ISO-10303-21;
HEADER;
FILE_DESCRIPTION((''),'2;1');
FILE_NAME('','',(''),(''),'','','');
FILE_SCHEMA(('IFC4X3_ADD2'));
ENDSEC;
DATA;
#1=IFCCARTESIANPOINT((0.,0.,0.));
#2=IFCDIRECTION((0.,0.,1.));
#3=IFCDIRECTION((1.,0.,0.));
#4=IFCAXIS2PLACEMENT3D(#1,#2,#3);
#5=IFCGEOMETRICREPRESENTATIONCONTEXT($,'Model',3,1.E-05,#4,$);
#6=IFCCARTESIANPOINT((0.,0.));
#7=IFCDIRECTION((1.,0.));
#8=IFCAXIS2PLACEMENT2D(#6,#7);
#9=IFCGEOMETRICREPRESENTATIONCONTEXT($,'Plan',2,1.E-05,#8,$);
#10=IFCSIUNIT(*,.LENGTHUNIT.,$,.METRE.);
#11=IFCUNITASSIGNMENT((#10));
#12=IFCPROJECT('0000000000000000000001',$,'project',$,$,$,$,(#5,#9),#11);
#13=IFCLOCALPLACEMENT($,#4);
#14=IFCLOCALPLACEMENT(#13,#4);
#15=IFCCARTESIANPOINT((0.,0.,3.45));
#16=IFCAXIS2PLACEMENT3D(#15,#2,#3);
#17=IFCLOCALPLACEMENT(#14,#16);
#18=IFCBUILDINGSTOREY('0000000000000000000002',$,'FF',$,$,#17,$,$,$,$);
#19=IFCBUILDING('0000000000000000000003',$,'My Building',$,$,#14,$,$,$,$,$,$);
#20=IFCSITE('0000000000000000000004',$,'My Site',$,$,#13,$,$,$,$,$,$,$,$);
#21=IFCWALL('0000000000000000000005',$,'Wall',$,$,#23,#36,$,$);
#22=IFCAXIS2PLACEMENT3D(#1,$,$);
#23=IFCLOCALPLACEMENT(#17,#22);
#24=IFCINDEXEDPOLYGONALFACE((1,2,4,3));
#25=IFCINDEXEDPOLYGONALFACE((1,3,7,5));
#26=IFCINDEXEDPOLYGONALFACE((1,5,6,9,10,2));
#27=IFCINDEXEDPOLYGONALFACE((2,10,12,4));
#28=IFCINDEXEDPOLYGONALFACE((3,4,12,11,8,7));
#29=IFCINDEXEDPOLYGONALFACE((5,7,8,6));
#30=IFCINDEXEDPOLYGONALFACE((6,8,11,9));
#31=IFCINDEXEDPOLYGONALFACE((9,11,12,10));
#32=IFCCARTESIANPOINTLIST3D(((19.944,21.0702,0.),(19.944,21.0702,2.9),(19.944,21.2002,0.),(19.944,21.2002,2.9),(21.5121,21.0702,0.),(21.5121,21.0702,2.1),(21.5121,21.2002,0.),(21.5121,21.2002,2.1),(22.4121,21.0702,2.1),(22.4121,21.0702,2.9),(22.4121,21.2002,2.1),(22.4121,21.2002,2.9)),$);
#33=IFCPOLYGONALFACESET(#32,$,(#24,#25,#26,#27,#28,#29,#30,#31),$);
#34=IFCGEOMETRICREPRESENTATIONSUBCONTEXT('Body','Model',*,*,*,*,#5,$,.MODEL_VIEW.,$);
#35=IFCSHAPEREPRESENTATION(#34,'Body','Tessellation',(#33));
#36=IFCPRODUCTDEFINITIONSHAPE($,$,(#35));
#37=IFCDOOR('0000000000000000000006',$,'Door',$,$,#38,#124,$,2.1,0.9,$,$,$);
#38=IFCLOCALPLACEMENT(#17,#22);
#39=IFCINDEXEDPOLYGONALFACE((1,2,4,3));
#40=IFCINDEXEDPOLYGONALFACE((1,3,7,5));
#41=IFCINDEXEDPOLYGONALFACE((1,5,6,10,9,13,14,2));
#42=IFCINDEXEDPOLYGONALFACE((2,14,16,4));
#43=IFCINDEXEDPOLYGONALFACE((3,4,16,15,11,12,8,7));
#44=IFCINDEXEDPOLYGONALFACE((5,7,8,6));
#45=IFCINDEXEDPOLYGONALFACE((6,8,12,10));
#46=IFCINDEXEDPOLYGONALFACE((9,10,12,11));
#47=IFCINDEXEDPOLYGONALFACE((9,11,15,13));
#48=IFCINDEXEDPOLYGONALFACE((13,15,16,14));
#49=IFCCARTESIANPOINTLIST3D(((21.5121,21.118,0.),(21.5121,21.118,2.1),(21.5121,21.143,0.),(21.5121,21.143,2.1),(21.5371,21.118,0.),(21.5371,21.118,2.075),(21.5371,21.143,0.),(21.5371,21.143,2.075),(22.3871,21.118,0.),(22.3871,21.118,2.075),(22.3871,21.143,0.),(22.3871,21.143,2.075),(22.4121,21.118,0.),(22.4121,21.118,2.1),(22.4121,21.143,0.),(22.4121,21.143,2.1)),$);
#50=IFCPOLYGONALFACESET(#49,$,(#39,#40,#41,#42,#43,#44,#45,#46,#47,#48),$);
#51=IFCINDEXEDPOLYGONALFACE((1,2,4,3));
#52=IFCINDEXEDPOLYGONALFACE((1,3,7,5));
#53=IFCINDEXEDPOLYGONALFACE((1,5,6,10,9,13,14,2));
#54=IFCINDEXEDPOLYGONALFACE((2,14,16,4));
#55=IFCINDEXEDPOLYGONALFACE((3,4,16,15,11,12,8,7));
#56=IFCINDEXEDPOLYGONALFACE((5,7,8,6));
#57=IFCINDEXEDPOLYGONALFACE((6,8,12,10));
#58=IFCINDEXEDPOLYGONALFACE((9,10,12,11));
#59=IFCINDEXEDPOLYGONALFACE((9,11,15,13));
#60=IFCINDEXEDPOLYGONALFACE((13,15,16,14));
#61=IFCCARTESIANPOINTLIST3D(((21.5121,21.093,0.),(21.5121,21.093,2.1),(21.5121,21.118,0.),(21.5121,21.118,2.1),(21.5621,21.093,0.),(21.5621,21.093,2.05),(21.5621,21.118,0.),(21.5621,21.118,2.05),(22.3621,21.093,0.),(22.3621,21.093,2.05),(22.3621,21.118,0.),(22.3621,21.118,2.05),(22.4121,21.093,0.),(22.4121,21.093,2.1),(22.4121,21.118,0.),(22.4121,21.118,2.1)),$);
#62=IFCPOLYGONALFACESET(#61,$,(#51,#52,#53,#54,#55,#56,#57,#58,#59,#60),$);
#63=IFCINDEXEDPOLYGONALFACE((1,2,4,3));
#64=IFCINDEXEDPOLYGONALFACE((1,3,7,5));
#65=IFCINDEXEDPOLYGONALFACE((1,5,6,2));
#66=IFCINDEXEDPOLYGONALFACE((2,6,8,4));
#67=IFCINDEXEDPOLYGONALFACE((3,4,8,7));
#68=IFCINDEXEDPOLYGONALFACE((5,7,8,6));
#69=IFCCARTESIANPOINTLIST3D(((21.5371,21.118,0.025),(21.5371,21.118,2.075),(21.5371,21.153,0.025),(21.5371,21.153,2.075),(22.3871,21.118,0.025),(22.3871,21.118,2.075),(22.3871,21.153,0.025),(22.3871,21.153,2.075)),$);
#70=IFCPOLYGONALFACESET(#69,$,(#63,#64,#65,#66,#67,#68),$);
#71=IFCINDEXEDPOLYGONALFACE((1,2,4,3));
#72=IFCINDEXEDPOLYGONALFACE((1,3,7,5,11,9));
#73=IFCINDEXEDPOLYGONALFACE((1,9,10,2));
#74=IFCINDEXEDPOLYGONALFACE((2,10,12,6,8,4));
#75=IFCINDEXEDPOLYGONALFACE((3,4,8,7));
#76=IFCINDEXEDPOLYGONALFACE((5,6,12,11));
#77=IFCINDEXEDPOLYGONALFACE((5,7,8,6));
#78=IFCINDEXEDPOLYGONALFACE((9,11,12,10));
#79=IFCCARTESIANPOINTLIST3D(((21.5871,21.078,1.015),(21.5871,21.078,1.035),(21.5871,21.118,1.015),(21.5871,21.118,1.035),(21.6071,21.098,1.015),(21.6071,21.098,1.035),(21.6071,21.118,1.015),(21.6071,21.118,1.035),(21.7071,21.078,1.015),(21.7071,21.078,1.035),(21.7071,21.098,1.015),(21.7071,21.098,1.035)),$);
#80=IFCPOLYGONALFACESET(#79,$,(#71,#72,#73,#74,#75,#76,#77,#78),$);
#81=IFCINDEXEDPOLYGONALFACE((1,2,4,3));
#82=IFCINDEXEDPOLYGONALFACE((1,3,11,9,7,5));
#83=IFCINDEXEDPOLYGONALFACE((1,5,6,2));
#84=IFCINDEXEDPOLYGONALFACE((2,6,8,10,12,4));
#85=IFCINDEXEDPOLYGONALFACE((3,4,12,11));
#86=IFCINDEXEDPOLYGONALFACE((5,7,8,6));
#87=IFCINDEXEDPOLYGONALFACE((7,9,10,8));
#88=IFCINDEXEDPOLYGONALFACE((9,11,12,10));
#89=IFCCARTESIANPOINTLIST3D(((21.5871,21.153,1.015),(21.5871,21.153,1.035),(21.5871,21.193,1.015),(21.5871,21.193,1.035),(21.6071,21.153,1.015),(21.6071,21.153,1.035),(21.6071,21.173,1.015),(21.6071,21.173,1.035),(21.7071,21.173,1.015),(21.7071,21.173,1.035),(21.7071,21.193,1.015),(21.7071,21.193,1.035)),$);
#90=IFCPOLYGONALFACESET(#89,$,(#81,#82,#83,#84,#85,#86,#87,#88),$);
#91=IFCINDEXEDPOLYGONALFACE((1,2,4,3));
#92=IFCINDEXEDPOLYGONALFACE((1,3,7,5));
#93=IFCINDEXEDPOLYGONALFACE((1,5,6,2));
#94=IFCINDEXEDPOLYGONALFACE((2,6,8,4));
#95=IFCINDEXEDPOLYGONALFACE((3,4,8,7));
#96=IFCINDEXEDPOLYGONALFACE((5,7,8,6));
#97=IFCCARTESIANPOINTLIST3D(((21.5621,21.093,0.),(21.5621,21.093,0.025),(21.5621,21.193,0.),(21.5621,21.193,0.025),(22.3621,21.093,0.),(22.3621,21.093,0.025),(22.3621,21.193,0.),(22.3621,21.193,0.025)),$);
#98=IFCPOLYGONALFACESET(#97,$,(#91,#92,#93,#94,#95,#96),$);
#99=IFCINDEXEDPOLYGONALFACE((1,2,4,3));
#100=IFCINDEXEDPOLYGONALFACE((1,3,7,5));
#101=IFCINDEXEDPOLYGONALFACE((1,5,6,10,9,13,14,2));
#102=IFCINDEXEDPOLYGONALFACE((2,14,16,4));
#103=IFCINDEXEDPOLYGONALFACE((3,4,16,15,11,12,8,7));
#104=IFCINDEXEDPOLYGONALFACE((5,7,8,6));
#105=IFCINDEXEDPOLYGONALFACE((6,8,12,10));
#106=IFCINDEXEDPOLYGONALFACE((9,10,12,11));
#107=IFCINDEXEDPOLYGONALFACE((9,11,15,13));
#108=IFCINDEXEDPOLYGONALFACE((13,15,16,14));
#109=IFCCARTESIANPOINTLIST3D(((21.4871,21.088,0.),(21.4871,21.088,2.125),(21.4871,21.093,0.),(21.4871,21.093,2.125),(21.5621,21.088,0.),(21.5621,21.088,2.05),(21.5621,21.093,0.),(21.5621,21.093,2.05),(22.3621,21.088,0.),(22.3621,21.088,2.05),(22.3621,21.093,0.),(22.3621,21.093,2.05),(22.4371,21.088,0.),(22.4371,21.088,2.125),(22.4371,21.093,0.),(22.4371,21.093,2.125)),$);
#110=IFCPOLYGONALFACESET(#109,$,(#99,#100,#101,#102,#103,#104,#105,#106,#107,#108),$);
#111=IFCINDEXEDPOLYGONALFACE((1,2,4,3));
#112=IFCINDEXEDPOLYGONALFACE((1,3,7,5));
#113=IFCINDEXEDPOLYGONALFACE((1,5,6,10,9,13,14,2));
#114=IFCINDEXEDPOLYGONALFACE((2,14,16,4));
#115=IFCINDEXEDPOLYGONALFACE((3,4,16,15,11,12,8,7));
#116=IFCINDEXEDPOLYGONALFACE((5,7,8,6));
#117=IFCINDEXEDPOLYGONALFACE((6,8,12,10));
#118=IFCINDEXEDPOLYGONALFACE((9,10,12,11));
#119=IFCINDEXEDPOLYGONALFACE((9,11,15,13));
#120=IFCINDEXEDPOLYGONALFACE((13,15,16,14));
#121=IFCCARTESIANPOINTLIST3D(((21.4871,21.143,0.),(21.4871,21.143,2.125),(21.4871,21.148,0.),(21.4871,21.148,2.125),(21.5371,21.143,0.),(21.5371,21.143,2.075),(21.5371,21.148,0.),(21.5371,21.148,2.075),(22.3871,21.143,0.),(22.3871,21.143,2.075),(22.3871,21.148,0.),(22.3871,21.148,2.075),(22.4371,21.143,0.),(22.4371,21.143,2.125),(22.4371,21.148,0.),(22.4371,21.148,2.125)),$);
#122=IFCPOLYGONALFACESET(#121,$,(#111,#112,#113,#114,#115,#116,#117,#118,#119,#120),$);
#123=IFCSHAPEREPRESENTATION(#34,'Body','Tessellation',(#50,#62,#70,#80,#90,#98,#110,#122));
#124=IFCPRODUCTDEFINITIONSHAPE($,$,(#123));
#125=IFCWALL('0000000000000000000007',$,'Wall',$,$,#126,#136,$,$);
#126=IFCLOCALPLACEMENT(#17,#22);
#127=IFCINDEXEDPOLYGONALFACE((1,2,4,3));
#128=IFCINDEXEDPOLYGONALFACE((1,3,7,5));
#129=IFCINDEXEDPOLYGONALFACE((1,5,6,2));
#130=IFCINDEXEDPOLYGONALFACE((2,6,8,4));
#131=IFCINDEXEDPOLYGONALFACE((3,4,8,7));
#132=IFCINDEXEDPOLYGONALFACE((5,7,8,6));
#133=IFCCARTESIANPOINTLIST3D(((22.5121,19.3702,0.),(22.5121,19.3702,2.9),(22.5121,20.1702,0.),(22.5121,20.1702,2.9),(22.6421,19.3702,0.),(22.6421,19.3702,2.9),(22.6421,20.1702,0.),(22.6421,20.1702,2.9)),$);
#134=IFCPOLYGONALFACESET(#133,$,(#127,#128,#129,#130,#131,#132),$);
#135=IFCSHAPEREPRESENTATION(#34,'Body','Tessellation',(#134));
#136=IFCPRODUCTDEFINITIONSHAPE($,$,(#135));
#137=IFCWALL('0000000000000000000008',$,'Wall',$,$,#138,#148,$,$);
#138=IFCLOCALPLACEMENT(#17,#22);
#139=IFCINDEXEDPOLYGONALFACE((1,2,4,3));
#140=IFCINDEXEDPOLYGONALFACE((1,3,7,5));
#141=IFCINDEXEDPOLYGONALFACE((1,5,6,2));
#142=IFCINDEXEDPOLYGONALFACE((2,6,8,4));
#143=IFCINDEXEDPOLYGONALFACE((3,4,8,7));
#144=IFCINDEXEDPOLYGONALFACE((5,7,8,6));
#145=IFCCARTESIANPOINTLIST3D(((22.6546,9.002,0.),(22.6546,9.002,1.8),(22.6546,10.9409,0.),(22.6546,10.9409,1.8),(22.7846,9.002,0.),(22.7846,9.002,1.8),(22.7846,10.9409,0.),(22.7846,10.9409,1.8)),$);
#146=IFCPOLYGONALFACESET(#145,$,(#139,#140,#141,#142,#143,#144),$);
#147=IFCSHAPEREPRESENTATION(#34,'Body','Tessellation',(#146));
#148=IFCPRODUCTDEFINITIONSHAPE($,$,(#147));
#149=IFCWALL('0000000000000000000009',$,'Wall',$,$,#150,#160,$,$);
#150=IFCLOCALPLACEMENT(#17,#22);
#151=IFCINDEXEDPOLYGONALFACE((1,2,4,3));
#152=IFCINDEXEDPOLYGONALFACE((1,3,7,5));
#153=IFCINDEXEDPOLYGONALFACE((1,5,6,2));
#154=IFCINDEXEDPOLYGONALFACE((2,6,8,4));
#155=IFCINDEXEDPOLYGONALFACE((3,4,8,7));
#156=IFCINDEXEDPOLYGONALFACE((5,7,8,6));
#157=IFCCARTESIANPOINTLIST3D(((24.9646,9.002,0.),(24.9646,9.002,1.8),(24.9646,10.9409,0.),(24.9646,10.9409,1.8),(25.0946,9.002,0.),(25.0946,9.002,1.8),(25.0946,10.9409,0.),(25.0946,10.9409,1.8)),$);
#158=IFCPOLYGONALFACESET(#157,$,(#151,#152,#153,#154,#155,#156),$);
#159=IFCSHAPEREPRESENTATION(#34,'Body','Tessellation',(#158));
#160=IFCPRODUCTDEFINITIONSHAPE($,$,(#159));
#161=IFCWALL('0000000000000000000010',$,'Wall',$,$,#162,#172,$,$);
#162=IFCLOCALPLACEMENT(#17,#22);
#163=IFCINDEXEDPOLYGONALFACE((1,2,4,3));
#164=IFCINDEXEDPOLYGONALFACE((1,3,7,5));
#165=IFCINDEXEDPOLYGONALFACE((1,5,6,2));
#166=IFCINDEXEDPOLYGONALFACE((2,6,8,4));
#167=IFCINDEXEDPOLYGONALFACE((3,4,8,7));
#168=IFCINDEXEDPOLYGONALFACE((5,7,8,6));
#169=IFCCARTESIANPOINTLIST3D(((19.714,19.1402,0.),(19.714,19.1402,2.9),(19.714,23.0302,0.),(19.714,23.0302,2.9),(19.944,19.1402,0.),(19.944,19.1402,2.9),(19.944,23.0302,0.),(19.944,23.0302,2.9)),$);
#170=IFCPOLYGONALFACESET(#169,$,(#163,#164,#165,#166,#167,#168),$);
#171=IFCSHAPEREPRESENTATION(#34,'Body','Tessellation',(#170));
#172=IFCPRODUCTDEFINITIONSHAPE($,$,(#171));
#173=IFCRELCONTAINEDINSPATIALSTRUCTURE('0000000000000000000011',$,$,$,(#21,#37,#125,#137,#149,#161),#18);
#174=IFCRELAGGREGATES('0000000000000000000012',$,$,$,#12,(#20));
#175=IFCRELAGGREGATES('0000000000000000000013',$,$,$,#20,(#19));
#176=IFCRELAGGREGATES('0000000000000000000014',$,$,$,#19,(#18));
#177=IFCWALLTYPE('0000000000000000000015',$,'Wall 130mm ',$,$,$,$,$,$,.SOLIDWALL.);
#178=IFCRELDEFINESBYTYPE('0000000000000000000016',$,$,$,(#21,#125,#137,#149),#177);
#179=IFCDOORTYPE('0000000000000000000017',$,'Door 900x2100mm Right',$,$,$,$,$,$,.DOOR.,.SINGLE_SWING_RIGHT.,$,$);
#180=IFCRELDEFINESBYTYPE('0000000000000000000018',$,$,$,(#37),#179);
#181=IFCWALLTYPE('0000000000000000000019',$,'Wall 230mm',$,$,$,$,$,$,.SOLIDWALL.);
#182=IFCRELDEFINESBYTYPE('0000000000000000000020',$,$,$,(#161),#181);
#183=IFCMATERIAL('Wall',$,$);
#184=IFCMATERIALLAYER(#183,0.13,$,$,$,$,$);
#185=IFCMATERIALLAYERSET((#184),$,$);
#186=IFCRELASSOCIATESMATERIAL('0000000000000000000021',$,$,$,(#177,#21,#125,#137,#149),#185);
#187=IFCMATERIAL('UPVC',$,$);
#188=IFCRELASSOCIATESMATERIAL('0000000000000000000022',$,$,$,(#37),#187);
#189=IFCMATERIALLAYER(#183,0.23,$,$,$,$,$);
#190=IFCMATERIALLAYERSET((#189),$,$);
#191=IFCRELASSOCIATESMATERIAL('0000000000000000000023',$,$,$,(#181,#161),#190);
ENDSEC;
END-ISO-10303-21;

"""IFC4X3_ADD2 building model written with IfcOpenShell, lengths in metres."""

from ifc_helpers import new_model, entity, si_unit, frame, origin_with_axes, origin_2d_with_axis, place, context, subcontext, project, spatial, line, indexed_curve, outline, extrude, shape, source, transform, mapped, material, layer, layer_set, layer_usage, type_object, type_shapes, element, fill, save


model = new_model("IFC4X3_ADD2")

# Units and contexts
model_context = context("Model", 3, precision=1e-05, world=origin_with_axes())
plan_context = context("Plan", 2, precision=1e-05, world=origin_2d_with_axis())
body_context_1 = subcontext(model_context, "Body", "Model", "MODEL_VIEW")
body_context_2 = subcontext(plan_context, "Body", "Plan", "PLAN_VIEW")
ifc_project = project(units=[si_unit("LENGTHUNIT", "METRE")], contexts=[model_context, plan_context])

# Site, building, storey
site_placement = place(None, origin_with_axes())
site = spatial("IfcSite", under=ifc_project, at=site_placement, Name="My Site")
building_placement = place(site_placement, origin_with_axes())
building = spatial("IfcBuilding", under=site, at=building_placement, Name="My Building")
storey_placement = place(building_placement, frame((0.0, 0.0, 3.45), z_axis=(0.0, 0.0, 1.0), x_axis=(1.0, 0.0, 0.0)))
storey = spatial("IfcBuildingStorey", under=building, at=storey_placement, Name="FF")

# Wall, opening, door
ifc_material_1 = material(Name="Wall")
ifc_layer_1 = layer(ifc_material_1, 0.13)
ifc_layer_set_1 = layer_set([ifc_layer_1])
ifc_layer_usage_1 = layer_usage(ifc_layer_set_1, "AXIS2", "POSITIVE", 0.0)
wall_type_1 = type_object("IfcWallType", Name="Wall 130mm ", PredefinedType="SOLIDWALL", material=ifc_layer_set_1)
wall_1_placement = place(storey_placement, frame((22.4121, 21.2002, 0.0), z_axis=(0.0, 0.0, 1.0), x_axis=(-1.0, 0.0, 0.0)))
wall_1 = element("IfcWall", 1, at=wall_1_placement, inside=storey, type_object=wall_type_1, material=ifc_layer_usage_1, Name="Wall", context=body_context_1, shape_type="SweptSolid", body=[
    extrude(outline(indexed_curve([(0.0, 0.0), (0.0, 0.13), (2.4681, 0.13), (2.4681, 0.0), (0.0, 0.0)], self_intersect=False)), origin_with_axes(), (0.0, 0.0, 1.0), 2.9),
])
shared_shape_1 = source(origin_with_axes(), body_context_1, "Body", "SweptSolid", [
    extrude(outline(indexed_curve([(0.0, 0.0), (0.9, 0.0), (0.9, 2.1), (0.0, 2.1)], segments=[line(1, 2, 3, 4, 1)])), frame((0.0, -0.6, 0.0), z_axis=(0.0, -1.0, 0.0), x_axis=(1.0, 0.0, 0.0)), (0.0, 0.0, -1.0), 1.2),
])
opening_1_placement = place(wall_1_placement, frame((0.9, 0.1072, 0.0), z_axis=(0.0, 0.0, 1.0), x_axis=(-1.0, 0.0, 0.0)))
opening_1 = element("IfcOpeningElement", 2, at=opening_1_placement, cuts=wall_1, PredefinedType="OPENING", context=body_context_1, shape_type="MappedRepresentation", body=[
    mapped(shared_shape_1, transform((0.0, 0.0, 0.0), x_axis=(1.0, 0.0, 0.0), y_axis=(0.0, 1.0, 0.0), z_axis=(0.0, 0.0, 1.0), scale=1.0)),
])
ifc_material_2 = material(Name="UPVC")
door_type_1 = type_object("IfcDoorType", Name="Door 900x2100mm Right", OperationType="SINGLE_SWING_RIGHT", PredefinedType="DOOR")
shared_shape_2 = source(origin_with_axes(), body_context_1, "Body", "SweptSolid", [
    extrude(outline(indexed_curve([(0.0, 0.0), (0.0, 2.1), (0.9, 2.1), (0.9, 0.0), (0.875, 0.0), (0.875, 2.075), (0.025, 2.075), (0.025, 0.0)], segments=[line(1, 2, 3, 4, 5, 6, 7, 8, 1)])), frame((0.0, 0.025, 0.0), z_axis=(0.0, -1.0, 0.0), x_axis=(1.0, 0.0, 0.0)), (0.0, 0.0, -1.0), 0.025),
    extrude(outline(indexed_curve([(0.0, 0.0), (0.0, 2.1), (0.9, 2.1), (0.9, 0.0), (0.85, 0.0), (0.85, 2.05), (0.05, 2.05), (0.05, 0.0)], segments=[line(1, 2, 3, 4, 5, 6, 7, 8, 1)])), frame((0.0, 0.0, 0.0), z_axis=(0.0, -1.0, 0.0), x_axis=(1.0, 0.0, 0.0)), (0.0, 0.0, -1.0), 0.025),
    extrude(outline(indexed_curve([(0.0, 0.0), (0.85, 0.0), (0.85, 0.035), (0.0, 0.035)], segments=[line(1, 2, 3, 4, 1)])), frame((0.025, 0.025, 0.025), z_axis=(0.0, 0.0, 1.0), x_axis=(1.0, 0.0, 0.0)), (0.0, 0.0, 1.0), 2.05),
    extrude(outline(indexed_curve([(0.0, 0.0), (0.0, -0.04), (0.12, -0.04), (0.12, -0.02), (0.02, -0.02), (0.02, 0.0)], segments=[line(1, 2, 3, 4, 5, 6, 1)])), frame((0.075, 0.025, 1.015), z_axis=(0.0, 0.0, 1.0), x_axis=(1.0, 0.0, 0.0)), (0.0, 0.0, 1.0), 0.02),
    extrude(outline(indexed_curve([(0.0, 0.0), (0.0, 0.04), (0.12, 0.04), (0.12, 0.02), (0.02, 0.02), (0.02, 0.0)], segments=[line(1, 2, 3, 4, 5, 6, 1)])), frame((0.075, 0.06, 1.015), z_axis=(0.0, 0.0, 1.0), x_axis=(1.0, 0.0, 0.0)), (0.0, 0.0, 1.0), 0.02),
    extrude(outline(indexed_curve([(0.0, 0.0), (0.8, 0.0), (0.8, 0.1), (0.0, 0.1)], segments=[line(1, 2, 3, 4, 1)])), frame((0.05, 0.0, 0.0), z_axis=(0.0, 0.0, 1.0), x_axis=(1.0, 0.0, 0.0)), (0.0, 0.0, 1.0), 0.025),
    extrude(outline(indexed_curve([(0.0, 0.0), (0.0, 2.125), (0.95, 2.125), (0.95, 0.0), (0.875, 0.0), (0.875, 2.05), (0.075, 2.05), (0.075, 0.0)], segments=[line(1, 2, 3, 4, 5, 6, 7, 8, 1)])), frame((-0.025, -0.005, 0.0), z_axis=(0.0, -1.0, 0.0), x_axis=(1.0, 0.0, 0.0)), (0.0, 0.0, -1.0), 0.005),
    extrude(outline(indexed_curve([(0.0, 0.0), (0.0, 2.125), (0.95, 2.125), (0.95, 0.0), (0.9, 0.0), (0.9, 2.075), (0.05, 2.075), (0.05, 0.0)], segments=[line(1, 2, 3, 4, 5, 6, 7, 8, 1)])), frame((-0.025, 0.05, 0.0), z_axis=(0.0, -1.0, 0.0), x_axis=(1.0, 0.0, 0.0)), (0.0, 0.0, -1.0), 0.005),
])
shared_shape_3 = source(origin_with_axes(), body_context_2, "Body", "Curve2D", [
    entity("IfcIndexedPolyCurve", entity("IfcCartesianPointList2D", [[0.0, 0.0], [0.0, 0.05], [0.025, 0.05], [0.025, 0.025], [0.05, 0.025], [0.05, 0.0]]), [entity("IfcLineIndex", [1, 2, 3, 4, 5, 6, 1])]),
    entity("IfcIndexedPolyCurve", entity("IfcCartesianPointList2D", [[0.9, 0.0], [0.9, 0.05], [0.875, 0.05], [0.875, 0.025], [0.85, 0.025], [0.85, 0.0]]), [entity("IfcLineIndex", [1, 2, 3, 4, 5, 6, 1])]),
    entity("IfcTrimmedCurve", entity("IfcEllipse", entity("IfcAxis2Placement2D", entity("IfcCartesianPoint", [0.84, 0.05]), entity("IfcDirection", [1.0, 0.0])), 0.815, 0.85), [entity("IfcCartesianPoint", [0.84, 0.9])], [entity("IfcCartesianPoint", [0.025, 0.05])], True, "CARTESIAN"),
    entity("IfcIndexedPolyCurve", entity("IfcCartesianPointList2D", [[0.875, 0.05], [0.84, 0.05], [0.84, 0.9], [0.875, 0.9]]), [entity("IfcLineIndex", [1, 2, 3, 4, 1])]),
])
type_shapes(door_type_1, [shared_shape_2, shared_shape_3])
door_1_placement = place(opening_1_placement, frame((0.0, 0.0, 0.0), z_axis=(0.0, 0.0, 1.0), x_axis=(1.0, 0.0, 0.0)))
door_1 = element("IfcDoor", 3, at=door_1_placement, inside=storey, type_object=door_type_1, material=ifc_material_2, Name="Door", OverallHeight=2.1, OverallWidth=0.9, shapes=[
    shape(body_context_1, "Body", "MappedRepresentation", [mapped(shared_shape_2, transform((0.0, 0.0, 0.0), x_axis=(1.0, 0.0, 0.0), y_axis=(0.0, 1.0, 0.0), z_axis=(0.0, 0.0, 1.0), scale=1.0))]),
    shape(body_context_2, "Body", "MappedRepresentation", [mapped(shared_shape_3, transform((0.0, 0.0, 0.0), x_axis=(1.0, 0.0, 0.0), y_axis=(0.0, 1.0, 0.0), z_axis=(0.0, 0.0, 1.0), scale=1.0))]),
])
fill(opening_1, door_1)

# Walls
ifc_layer_usage_2 = layer_usage(ifc_layer_set_1, "AXIS2", "POSITIVE", 0.0)
wall_2_placement = place(storey_placement, frame((22.6421, 19.3702, 0.0), z_axis=(0.0, 0.0, 1.0), x_axis=(0.000001, 1.0, 0.0)))
element("IfcWall", 4, at=wall_2_placement, inside=storey, type_object=wall_type_1, material=ifc_layer_usage_2, Name="Wall", context=body_context_1, shape_type="SweptSolid", body=[
    extrude(outline(indexed_curve([(0.0, 0.0), (0.0, 0.13), (0.8, 0.13), (0.8, 0.0), (0.0, 0.0)], self_intersect=False)), origin_with_axes(), (0.0, 0.0, 1.0), 2.9),
])
ifc_layer_usage_3 = layer_usage(ifc_layer_set_1, "AXIS2", "POSITIVE", 0.0)
wall_3_placement = place(storey_placement, frame((22.7846, 9.002, 0.0), z_axis=(0.0, 0.0, 1.0), x_axis=(0.0, 1.0, 0.0)))
element("IfcWall", 5, at=wall_3_placement, inside=storey, type_object=wall_type_1, material=ifc_layer_usage_3, Name="Wall", context=body_context_1, shape_type="SweptSolid", body=[
    extrude(outline(indexed_curve([(0.0, 0.0), (0.0, 0.13), (1.9389, 0.13), (1.9389, 0.0), (0.0, 0.0)], self_intersect=False)), origin_with_axes(), (0.0, 0.0, 1.0), 1.8),
])
ifc_layer_usage_4 = layer_usage(ifc_layer_set_1, "AXIS2", "POSITIVE", 0.0)
wall_4_placement = place(storey_placement, frame((25.0946, 9.002, 0.0), z_axis=(0.0, 0.0, 1.0), x_axis=(0.0, 1.0, 0.0)))
element("IfcWall", 6, at=wall_4_placement, inside=storey, type_object=wall_type_1, material=ifc_layer_usage_4, Name="Wall", context=body_context_1, shape_type="SweptSolid", body=[
    extrude(outline(indexed_curve([(0.0, 0.0), (0.0, 0.13), (1.9389, 0.13), (1.9389, 0.0), (0.0, 0.0)], self_intersect=False)), origin_with_axes(), (0.0, 0.0, 1.0), 1.8),
])
ifc_layer_2 = layer(ifc_material_1, 0.23)
ifc_layer_set_2 = layer_set([ifc_layer_2])
ifc_layer_usage_5 = layer_usage(ifc_layer_set_2, "AXIS2", "POSITIVE", 0.0)
wall_type_2 = type_object("IfcWallType", Name="Wall 230mm", PredefinedType="SOLIDWALL", material=ifc_layer_set_2)
wall_5_placement = place(storey_placement, frame((19.944, 19.1402, 0.0), z_axis=(0.0, 0.0, 1.0), x_axis=(0.000001, 1.0, 0.0)))
element("IfcWall", 7, at=wall_5_placement, inside=storey, type_object=wall_type_2, material=ifc_layer_usage_5, Name="Wall", context=body_context_1, shape_type="SweptSolid", body=[
    extrude(outline(indexed_curve([(0.0, 0.0), (0.0, 0.23), (3.89, 0.23), (3.89, 0.0), (0.0, 0.0)], self_intersect=False)), origin_with_axes(), (0.0, 0.0, 1.0), 2.9),
])

save(model, "model.ifc")
